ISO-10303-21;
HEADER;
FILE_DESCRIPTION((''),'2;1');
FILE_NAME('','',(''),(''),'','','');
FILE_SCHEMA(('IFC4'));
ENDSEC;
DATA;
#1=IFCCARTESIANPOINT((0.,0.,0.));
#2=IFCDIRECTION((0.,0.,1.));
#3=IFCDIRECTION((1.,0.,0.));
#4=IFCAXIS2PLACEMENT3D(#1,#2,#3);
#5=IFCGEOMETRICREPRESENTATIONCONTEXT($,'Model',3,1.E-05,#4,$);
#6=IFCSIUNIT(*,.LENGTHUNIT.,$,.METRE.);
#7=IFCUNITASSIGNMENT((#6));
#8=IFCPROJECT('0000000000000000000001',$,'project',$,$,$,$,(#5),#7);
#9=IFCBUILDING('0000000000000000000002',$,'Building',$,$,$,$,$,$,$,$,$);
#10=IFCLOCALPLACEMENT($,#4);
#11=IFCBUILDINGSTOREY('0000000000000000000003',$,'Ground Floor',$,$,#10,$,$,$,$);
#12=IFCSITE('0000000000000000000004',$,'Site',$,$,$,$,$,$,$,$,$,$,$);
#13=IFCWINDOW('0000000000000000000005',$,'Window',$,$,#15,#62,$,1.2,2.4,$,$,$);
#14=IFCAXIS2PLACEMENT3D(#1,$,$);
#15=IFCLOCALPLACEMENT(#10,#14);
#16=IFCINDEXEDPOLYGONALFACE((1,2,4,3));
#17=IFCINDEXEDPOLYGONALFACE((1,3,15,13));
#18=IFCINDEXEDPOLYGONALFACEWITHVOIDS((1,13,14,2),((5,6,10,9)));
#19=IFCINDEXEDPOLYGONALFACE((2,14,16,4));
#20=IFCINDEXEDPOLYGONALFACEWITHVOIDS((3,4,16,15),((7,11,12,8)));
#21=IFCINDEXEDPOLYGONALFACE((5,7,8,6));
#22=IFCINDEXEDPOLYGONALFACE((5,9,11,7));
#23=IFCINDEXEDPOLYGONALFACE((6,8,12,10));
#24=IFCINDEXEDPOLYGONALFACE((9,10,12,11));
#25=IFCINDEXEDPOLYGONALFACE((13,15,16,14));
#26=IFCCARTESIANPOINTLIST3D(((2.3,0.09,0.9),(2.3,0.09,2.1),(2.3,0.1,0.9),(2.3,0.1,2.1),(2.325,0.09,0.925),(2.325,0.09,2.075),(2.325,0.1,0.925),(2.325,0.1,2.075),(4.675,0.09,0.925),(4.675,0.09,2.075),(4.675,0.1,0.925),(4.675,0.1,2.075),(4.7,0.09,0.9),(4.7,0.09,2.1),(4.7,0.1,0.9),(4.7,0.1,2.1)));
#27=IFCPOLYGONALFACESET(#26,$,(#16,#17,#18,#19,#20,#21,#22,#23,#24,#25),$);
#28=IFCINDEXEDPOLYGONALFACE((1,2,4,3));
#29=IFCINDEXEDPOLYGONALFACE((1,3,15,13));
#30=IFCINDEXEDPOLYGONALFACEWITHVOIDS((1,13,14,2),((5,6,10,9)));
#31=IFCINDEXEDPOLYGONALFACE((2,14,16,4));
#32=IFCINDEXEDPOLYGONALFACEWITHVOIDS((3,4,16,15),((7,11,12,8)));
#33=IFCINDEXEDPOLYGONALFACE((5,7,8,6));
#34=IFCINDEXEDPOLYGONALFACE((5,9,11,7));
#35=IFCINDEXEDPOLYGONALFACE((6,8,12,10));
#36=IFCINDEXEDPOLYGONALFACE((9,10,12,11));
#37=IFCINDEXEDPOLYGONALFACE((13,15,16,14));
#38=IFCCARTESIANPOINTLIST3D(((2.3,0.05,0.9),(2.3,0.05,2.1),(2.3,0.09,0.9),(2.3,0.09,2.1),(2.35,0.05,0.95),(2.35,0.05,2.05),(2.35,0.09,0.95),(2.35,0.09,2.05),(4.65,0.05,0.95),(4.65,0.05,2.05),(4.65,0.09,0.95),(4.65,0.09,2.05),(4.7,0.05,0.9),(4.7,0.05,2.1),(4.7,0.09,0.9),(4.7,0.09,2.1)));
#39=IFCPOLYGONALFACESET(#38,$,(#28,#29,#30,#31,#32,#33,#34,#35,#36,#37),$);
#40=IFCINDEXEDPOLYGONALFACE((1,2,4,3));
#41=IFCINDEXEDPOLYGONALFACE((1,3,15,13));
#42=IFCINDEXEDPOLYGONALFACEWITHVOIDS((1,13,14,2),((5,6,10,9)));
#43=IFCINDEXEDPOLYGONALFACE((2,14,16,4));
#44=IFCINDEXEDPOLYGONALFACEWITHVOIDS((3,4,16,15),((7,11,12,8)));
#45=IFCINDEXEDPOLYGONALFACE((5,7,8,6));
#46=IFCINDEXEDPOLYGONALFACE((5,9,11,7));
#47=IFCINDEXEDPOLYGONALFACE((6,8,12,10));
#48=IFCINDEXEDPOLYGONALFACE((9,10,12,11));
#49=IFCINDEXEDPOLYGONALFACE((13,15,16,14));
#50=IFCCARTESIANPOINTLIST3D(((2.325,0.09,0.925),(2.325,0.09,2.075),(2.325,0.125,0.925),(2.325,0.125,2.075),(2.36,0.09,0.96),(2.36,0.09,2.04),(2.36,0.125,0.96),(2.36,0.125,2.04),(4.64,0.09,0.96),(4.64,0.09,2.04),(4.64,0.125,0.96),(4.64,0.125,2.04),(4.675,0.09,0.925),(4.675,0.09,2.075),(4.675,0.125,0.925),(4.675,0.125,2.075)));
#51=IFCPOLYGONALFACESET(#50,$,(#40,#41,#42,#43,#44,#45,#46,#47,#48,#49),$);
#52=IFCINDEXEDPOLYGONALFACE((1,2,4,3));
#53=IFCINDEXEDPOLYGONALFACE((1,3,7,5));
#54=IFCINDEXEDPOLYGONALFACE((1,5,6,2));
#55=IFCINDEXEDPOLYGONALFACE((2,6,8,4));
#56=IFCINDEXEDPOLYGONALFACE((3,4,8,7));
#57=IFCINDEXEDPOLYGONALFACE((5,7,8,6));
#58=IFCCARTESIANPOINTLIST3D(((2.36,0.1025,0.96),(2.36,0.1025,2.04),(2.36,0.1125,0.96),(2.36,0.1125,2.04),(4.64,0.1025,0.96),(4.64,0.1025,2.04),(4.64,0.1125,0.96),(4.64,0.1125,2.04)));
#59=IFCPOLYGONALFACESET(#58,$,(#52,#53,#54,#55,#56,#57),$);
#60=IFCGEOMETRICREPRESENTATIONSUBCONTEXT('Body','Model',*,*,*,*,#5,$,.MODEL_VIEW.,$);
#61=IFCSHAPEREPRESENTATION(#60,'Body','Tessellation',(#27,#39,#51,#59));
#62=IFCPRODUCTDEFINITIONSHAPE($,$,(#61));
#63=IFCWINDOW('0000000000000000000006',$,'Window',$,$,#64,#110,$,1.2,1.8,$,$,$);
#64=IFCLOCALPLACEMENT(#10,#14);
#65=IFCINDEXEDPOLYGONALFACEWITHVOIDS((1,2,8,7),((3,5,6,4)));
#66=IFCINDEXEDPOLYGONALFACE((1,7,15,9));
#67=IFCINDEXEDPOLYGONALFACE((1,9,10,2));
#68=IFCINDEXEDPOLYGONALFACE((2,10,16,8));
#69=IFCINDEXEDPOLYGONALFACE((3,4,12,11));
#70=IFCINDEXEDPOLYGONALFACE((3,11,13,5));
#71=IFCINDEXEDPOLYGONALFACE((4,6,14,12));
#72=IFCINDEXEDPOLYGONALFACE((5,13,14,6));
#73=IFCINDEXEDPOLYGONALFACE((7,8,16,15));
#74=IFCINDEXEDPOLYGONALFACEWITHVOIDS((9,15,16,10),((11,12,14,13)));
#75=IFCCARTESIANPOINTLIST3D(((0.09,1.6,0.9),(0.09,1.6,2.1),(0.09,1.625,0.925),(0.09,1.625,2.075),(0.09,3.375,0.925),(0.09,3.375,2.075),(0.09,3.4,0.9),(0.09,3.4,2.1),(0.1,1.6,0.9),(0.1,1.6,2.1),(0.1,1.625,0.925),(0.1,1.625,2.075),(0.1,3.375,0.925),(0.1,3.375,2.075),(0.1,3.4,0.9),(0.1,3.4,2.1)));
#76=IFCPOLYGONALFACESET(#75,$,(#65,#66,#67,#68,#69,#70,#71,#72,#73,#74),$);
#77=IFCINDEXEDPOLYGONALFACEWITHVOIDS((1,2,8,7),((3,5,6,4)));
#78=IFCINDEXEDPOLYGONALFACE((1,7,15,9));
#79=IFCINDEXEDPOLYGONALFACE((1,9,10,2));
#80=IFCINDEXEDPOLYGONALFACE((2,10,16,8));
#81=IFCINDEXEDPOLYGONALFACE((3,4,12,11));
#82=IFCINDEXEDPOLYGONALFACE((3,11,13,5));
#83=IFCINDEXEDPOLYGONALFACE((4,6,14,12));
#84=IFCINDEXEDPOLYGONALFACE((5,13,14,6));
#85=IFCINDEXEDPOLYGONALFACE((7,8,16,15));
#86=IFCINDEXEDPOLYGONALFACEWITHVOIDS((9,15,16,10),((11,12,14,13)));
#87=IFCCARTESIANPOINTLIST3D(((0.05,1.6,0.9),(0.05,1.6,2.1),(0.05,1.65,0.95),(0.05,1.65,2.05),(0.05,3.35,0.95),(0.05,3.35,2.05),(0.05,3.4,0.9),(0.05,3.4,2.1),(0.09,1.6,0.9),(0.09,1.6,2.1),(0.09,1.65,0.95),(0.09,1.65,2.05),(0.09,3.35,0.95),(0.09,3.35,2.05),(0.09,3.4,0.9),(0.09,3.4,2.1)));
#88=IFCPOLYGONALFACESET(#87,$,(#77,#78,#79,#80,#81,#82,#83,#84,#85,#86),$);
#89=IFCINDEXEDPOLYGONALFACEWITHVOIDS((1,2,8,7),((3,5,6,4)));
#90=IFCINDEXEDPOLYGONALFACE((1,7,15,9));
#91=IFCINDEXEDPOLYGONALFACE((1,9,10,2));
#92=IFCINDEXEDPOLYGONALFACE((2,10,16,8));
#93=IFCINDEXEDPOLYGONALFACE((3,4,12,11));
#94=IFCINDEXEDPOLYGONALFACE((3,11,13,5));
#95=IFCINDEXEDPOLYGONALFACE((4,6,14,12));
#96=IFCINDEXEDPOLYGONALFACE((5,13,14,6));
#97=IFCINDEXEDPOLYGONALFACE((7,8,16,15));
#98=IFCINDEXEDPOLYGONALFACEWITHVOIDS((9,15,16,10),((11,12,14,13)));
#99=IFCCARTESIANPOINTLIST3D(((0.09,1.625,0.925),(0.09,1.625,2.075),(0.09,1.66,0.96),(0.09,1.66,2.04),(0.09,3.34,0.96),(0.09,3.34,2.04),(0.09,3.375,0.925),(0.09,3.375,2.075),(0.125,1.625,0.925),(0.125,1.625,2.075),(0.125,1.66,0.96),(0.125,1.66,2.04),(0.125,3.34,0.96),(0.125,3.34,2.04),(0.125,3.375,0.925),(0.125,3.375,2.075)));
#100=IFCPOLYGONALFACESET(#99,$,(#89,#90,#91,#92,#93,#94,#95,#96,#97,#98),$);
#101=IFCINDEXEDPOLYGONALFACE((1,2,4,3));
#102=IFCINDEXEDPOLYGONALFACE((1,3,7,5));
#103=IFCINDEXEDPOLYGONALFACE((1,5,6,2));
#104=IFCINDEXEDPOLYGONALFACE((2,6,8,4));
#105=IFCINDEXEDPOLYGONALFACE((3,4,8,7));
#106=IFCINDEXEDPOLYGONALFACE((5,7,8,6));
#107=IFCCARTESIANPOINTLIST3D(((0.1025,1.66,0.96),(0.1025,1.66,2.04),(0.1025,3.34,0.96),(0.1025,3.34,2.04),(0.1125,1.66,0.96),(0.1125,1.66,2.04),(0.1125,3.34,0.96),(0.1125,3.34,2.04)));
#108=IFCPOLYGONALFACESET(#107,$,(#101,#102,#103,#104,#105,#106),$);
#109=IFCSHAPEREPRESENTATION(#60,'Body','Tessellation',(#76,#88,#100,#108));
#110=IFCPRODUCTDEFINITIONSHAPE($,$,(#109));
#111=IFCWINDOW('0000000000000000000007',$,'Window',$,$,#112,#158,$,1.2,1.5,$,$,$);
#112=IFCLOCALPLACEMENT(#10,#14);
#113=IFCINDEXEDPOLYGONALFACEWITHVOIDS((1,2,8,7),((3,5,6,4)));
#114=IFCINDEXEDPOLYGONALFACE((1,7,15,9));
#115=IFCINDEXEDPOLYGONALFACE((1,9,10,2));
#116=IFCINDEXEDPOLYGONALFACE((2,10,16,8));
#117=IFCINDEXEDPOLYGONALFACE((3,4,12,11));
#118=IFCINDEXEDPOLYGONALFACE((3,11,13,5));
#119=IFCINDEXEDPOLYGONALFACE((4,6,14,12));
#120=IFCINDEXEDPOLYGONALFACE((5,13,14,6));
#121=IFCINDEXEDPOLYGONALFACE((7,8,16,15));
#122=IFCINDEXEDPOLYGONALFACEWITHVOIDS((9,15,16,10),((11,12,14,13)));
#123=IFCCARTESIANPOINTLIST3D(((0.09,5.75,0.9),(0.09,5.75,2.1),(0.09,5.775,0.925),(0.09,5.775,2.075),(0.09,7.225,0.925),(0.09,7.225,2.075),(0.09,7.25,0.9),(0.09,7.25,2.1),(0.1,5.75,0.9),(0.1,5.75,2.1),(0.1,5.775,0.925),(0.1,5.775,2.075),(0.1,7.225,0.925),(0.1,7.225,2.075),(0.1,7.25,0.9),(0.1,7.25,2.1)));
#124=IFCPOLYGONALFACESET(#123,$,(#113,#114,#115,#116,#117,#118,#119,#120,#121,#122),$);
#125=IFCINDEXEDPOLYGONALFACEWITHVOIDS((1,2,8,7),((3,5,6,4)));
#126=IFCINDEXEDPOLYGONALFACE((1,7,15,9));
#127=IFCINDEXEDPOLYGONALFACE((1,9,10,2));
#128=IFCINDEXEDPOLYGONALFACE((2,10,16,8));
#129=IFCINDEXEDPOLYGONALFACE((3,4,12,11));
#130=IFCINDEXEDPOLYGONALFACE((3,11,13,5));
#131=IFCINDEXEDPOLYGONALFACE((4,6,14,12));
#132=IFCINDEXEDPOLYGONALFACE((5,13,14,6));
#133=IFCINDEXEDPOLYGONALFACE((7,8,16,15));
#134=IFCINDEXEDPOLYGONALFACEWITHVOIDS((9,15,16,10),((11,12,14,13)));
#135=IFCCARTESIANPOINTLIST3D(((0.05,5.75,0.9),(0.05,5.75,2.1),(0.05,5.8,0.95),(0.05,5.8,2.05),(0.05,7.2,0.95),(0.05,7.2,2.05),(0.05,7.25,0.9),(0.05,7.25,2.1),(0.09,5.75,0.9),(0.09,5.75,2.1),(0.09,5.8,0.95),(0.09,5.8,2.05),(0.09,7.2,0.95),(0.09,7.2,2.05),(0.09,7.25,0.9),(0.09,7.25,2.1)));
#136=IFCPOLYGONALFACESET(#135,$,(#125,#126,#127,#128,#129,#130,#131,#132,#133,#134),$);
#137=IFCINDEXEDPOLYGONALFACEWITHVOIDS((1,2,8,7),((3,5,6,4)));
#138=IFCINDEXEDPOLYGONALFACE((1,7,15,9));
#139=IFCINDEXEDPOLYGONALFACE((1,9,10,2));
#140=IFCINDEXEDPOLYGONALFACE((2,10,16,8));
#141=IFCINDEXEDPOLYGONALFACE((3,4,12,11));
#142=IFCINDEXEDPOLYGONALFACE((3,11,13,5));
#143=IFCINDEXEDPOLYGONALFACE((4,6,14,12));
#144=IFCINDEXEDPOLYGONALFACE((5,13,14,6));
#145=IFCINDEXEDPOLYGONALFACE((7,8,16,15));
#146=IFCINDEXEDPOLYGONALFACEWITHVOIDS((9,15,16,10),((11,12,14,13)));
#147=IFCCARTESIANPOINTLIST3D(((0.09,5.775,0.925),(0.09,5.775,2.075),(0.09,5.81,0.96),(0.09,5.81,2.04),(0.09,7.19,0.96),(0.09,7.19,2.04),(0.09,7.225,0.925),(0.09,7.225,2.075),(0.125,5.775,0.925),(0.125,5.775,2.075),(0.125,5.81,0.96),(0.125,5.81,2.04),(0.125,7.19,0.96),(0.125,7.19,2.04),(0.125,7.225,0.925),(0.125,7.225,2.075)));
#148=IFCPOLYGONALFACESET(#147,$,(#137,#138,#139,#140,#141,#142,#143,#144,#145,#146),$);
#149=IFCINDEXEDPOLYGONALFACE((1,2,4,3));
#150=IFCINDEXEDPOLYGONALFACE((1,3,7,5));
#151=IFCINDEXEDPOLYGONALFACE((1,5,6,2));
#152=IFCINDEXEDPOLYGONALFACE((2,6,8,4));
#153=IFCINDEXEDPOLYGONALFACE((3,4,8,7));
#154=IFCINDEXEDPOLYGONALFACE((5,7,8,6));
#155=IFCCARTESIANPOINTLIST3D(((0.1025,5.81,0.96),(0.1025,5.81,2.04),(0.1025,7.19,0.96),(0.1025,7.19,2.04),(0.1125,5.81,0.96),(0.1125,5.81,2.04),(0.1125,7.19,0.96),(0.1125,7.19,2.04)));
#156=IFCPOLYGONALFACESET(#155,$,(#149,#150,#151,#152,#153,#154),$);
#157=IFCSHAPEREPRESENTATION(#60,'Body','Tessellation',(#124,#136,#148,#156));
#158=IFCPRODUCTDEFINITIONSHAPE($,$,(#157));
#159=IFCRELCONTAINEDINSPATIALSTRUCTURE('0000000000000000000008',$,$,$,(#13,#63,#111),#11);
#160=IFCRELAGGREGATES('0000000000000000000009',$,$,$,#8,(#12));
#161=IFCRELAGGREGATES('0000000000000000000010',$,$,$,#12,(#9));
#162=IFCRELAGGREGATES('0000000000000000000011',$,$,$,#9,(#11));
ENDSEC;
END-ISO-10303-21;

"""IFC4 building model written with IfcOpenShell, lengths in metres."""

from ifc_helpers import new_model, si_unit, frame, origin_with_axes, place, context, subcontext, project, spatial, line, indexed_curve, outline, extrude, element, save


model = new_model("IFC4")

# Units and contexts
model_context = context("Model", 3, precision=1e-05, world=origin_with_axes())
body_context = subcontext(model_context, "Body", "Model", "MODEL_VIEW")
ifc_project = project(units=[si_unit("LENGTHUNIT", "METRE")], contexts=[model_context])

# Site, building, storey
site = spatial("IfcSite", under=ifc_project, Name="Site")
building = spatial("IfcBuilding", under=site, Name="Building")
storey_placement = place(None, origin_with_axes())
storey = spatial("IfcBuildingStorey", under=building, at=storey_placement, Name="Ground Floor")

# Windows
window_1_placement = place(storey_placement, frame((2.3, 0.0, 0.9), z_axis=(0.0, 0.0, 1.0), x_axis=(1.0, 0.0, 0.0)))
element("IfcWindow", 1, at=window_1_placement, inside=storey, Name="Window", OverallHeight=1.2, OverallWidth=2.4, context=body_context, shape_type="SweptSolid", body=[
    extrude(outline(indexed_curve([(0.0, 0.0), (2.4, 0.0), (2.4, 1.2), (0.0, 1.2)], segments=[line(1, 2, 3, 4, 1)]), holes=[indexed_curve([(0.025, 0.025), (2.375, 0.025), (2.375, 1.175), (0.025, 1.175)], segments=[line(1, 2, 3, 4, 1)])]), frame((0.0, 0.09, 0.0), z_axis=(0.0, -1.0, 0.0), x_axis=(1.0, 0.0, 0.0)), (0.0, 0.0, -1.0), 0.01),
    extrude(outline(indexed_curve([(0.0, 0.0), (2.4, 0.0), (2.4, 1.2), (0.0, 1.2)], segments=[line(1, 2, 3, 4, 1)]), holes=[indexed_curve([(0.05, 0.05), (2.35, 0.05), (2.35, 1.15), (0.05, 1.15)], segments=[line(1, 2, 3, 4, 1)])]), frame((0.0, 0.05, 0.0), z_axis=(0.0, -1.0, 0.0), x_axis=(1.0, 0.0, 0.0)), (0.0, 0.0, -1.0), 0.04),
    extrude(outline(indexed_curve([(0.0, 0.0), (2.35, 0.0), (2.35, 1.15), (0.0, 1.15)], segments=[line(1, 2, 3, 4, 1)]), holes=[indexed_curve([(0.035, 0.035), (2.315, 0.035), (2.315, 1.115), (0.035, 1.115)], segments=[line(1, 2, 3, 4, 1)])]), frame((0.025, 0.09, 0.025), z_axis=(0.0, -1.0, 0.0), x_axis=(1.0, 0.0, 0.0)), (0.0, 0.0, -1.0), 0.035),
    extrude(outline(indexed_curve([(0.035, 0.035), (2.315, 0.035), (2.315, 1.115), (0.035, 1.115)], segments=[line(1, 2, 3, 4, 1)])), frame((0.025, 0.1025, 0.025), z_axis=(0.0, -1.0, 0.0), x_axis=(1.0, 0.0, 0.0)), (0.0, 0.0, -1.0), 0.01),
])
window_2_placement = place(storey_placement, frame((0.0, 3.4, 0.9), z_axis=(0.0, 0.0, 1.0), x_axis=(0.0, -1.0, 0.0)))
element("IfcWindow", 2, at=window_2_placement, inside=storey, Name="Window", OverallHeight=1.2, OverallWidth=1.8, context=body_context, shape_type="SweptSolid", body=[
    extrude(outline(indexed_curve([(0.0, 0.0), (1.8, 0.0), (1.8, 1.2), (0.0, 1.2)], segments=[line(1, 2, 3, 4, 1)]), holes=[indexed_curve([(0.025, 0.025), (1.775, 0.025), (1.775, 1.175), (0.025, 1.175)], segments=[line(1, 2, 3, 4, 1)])]), frame((0.0, 0.09, 0.0), z_axis=(0.0, -1.0, 0.0), x_axis=(1.0, 0.0, 0.0)), (0.0, 0.0, -1.0), 0.01),
    extrude(outline(indexed_curve([(0.0, 0.0), (1.8, 0.0), (1.8, 1.2), (0.0, 1.2)], segments=[line(1, 2, 3, 4, 1)]), holes=[indexed_curve([(0.05, 0.05), (1.75, 0.05), (1.75, 1.15), (0.05, 1.15)], segments=[line(1, 2, 3, 4, 1)])]), frame((0.0, 0.05, 0.0), z_axis=(0.0, -1.0, 0.0), x_axis=(1.0, 0.0, 0.0)), (0.0, 0.0, -1.0), 0.04),
    extrude(outline(indexed_curve([(0.0, 0.0), (1.75, 0.0), (1.75, 1.15), (0.0, 1.15)], segments=[line(1, 2, 3, 4, 1)]), holes=[indexed_curve([(0.035, 0.035), (1.715, 0.035), (1.715, 1.115), (0.035, 1.115)], segments=[line(1, 2, 3, 4, 1)])]), frame((0.025, 0.09, 0.025), z_axis=(0.0, -1.0, 0.0), x_axis=(1.0, 0.0, 0.0)), (0.0, 0.0, -1.0), 0.035),
    extrude(outline(indexed_curve([(0.035, 0.035), (1.715, 0.035), (1.715, 1.115), (0.035, 1.115)], segments=[line(1, 2, 3, 4, 1)])), frame((0.025, 0.1025, 0.025), z_axis=(0.0, -1.0, 0.0), x_axis=(1.0, 0.0, 0.0)), (0.0, 0.0, -1.0), 0.01),
])
window_3_placement = place(storey_placement, frame((0.0, 7.25, 0.9), z_axis=(0.0, 0.0, 1.0), x_axis=(0.0, -1.0, 0.0)))
element("IfcWindow", 3, at=window_3_placement, inside=storey, Name="Window", OverallHeight=1.2, OverallWidth=1.5, context=body_context, shape_type="SweptSolid", body=[
    extrude(outline(indexed_curve([(0.0, 0.0), (1.5, 0.0), (1.5, 1.2), (0.0, 1.2)], segments=[line(1, 2, 3, 4, 1)]), holes=[indexed_curve([(0.025, 0.025), (1.475, 0.025), (1.475, 1.175), (0.025, 1.175)], segments=[line(1, 2, 3, 4, 1)])]), frame((0.0, 0.09, 0.0), z_axis=(0.0, -1.0, 0.0), x_axis=(1.0, 0.0, 0.0)), (0.0, 0.0, -1.0), 0.01),
    extrude(outline(indexed_curve([(0.0, 0.0), (1.5, 0.0), (1.5, 1.2), (0.0, 1.2)], segments=[line(1, 2, 3, 4, 1)]), holes=[indexed_curve([(0.05, 0.05), (1.45, 0.05), (1.45, 1.15), (0.05, 1.15)], segments=[line(1, 2, 3, 4, 1)])]), frame((0.0, 0.05, 0.0), z_axis=(0.0, -1.0, 0.0), x_axis=(1.0, 0.0, 0.0)), (0.0, 0.0, -1.0), 0.04),
    extrude(outline(indexed_curve([(0.0, 0.0), (1.45, 0.0), (1.45, 1.15), (0.0, 1.15)], segments=[line(1, 2, 3, 4, 1)]), holes=[indexed_curve([(0.035, 0.035), (1.415, 0.035), (1.415, 1.115), (0.035, 1.115)], segments=[line(1, 2, 3, 4, 1)])]), frame((0.025, 0.09, 0.025), z_axis=(0.0, -1.0, 0.0), x_axis=(1.0, 0.0, 0.0)), (0.0, 0.0, -1.0), 0.035),
    extrude(outline(indexed_curve([(0.035, 0.035), (1.415, 0.035), (1.415, 1.115), (0.035, 1.115)], segments=[line(1, 2, 3, 4, 1)])), frame((0.025, 0.1025, 0.025), z_axis=(0.0, -1.0, 0.0), x_axis=(1.0, 0.0, 0.0)), (0.0, 0.0, -1.0), 0.01),
])

save(model, "model.ifc")
